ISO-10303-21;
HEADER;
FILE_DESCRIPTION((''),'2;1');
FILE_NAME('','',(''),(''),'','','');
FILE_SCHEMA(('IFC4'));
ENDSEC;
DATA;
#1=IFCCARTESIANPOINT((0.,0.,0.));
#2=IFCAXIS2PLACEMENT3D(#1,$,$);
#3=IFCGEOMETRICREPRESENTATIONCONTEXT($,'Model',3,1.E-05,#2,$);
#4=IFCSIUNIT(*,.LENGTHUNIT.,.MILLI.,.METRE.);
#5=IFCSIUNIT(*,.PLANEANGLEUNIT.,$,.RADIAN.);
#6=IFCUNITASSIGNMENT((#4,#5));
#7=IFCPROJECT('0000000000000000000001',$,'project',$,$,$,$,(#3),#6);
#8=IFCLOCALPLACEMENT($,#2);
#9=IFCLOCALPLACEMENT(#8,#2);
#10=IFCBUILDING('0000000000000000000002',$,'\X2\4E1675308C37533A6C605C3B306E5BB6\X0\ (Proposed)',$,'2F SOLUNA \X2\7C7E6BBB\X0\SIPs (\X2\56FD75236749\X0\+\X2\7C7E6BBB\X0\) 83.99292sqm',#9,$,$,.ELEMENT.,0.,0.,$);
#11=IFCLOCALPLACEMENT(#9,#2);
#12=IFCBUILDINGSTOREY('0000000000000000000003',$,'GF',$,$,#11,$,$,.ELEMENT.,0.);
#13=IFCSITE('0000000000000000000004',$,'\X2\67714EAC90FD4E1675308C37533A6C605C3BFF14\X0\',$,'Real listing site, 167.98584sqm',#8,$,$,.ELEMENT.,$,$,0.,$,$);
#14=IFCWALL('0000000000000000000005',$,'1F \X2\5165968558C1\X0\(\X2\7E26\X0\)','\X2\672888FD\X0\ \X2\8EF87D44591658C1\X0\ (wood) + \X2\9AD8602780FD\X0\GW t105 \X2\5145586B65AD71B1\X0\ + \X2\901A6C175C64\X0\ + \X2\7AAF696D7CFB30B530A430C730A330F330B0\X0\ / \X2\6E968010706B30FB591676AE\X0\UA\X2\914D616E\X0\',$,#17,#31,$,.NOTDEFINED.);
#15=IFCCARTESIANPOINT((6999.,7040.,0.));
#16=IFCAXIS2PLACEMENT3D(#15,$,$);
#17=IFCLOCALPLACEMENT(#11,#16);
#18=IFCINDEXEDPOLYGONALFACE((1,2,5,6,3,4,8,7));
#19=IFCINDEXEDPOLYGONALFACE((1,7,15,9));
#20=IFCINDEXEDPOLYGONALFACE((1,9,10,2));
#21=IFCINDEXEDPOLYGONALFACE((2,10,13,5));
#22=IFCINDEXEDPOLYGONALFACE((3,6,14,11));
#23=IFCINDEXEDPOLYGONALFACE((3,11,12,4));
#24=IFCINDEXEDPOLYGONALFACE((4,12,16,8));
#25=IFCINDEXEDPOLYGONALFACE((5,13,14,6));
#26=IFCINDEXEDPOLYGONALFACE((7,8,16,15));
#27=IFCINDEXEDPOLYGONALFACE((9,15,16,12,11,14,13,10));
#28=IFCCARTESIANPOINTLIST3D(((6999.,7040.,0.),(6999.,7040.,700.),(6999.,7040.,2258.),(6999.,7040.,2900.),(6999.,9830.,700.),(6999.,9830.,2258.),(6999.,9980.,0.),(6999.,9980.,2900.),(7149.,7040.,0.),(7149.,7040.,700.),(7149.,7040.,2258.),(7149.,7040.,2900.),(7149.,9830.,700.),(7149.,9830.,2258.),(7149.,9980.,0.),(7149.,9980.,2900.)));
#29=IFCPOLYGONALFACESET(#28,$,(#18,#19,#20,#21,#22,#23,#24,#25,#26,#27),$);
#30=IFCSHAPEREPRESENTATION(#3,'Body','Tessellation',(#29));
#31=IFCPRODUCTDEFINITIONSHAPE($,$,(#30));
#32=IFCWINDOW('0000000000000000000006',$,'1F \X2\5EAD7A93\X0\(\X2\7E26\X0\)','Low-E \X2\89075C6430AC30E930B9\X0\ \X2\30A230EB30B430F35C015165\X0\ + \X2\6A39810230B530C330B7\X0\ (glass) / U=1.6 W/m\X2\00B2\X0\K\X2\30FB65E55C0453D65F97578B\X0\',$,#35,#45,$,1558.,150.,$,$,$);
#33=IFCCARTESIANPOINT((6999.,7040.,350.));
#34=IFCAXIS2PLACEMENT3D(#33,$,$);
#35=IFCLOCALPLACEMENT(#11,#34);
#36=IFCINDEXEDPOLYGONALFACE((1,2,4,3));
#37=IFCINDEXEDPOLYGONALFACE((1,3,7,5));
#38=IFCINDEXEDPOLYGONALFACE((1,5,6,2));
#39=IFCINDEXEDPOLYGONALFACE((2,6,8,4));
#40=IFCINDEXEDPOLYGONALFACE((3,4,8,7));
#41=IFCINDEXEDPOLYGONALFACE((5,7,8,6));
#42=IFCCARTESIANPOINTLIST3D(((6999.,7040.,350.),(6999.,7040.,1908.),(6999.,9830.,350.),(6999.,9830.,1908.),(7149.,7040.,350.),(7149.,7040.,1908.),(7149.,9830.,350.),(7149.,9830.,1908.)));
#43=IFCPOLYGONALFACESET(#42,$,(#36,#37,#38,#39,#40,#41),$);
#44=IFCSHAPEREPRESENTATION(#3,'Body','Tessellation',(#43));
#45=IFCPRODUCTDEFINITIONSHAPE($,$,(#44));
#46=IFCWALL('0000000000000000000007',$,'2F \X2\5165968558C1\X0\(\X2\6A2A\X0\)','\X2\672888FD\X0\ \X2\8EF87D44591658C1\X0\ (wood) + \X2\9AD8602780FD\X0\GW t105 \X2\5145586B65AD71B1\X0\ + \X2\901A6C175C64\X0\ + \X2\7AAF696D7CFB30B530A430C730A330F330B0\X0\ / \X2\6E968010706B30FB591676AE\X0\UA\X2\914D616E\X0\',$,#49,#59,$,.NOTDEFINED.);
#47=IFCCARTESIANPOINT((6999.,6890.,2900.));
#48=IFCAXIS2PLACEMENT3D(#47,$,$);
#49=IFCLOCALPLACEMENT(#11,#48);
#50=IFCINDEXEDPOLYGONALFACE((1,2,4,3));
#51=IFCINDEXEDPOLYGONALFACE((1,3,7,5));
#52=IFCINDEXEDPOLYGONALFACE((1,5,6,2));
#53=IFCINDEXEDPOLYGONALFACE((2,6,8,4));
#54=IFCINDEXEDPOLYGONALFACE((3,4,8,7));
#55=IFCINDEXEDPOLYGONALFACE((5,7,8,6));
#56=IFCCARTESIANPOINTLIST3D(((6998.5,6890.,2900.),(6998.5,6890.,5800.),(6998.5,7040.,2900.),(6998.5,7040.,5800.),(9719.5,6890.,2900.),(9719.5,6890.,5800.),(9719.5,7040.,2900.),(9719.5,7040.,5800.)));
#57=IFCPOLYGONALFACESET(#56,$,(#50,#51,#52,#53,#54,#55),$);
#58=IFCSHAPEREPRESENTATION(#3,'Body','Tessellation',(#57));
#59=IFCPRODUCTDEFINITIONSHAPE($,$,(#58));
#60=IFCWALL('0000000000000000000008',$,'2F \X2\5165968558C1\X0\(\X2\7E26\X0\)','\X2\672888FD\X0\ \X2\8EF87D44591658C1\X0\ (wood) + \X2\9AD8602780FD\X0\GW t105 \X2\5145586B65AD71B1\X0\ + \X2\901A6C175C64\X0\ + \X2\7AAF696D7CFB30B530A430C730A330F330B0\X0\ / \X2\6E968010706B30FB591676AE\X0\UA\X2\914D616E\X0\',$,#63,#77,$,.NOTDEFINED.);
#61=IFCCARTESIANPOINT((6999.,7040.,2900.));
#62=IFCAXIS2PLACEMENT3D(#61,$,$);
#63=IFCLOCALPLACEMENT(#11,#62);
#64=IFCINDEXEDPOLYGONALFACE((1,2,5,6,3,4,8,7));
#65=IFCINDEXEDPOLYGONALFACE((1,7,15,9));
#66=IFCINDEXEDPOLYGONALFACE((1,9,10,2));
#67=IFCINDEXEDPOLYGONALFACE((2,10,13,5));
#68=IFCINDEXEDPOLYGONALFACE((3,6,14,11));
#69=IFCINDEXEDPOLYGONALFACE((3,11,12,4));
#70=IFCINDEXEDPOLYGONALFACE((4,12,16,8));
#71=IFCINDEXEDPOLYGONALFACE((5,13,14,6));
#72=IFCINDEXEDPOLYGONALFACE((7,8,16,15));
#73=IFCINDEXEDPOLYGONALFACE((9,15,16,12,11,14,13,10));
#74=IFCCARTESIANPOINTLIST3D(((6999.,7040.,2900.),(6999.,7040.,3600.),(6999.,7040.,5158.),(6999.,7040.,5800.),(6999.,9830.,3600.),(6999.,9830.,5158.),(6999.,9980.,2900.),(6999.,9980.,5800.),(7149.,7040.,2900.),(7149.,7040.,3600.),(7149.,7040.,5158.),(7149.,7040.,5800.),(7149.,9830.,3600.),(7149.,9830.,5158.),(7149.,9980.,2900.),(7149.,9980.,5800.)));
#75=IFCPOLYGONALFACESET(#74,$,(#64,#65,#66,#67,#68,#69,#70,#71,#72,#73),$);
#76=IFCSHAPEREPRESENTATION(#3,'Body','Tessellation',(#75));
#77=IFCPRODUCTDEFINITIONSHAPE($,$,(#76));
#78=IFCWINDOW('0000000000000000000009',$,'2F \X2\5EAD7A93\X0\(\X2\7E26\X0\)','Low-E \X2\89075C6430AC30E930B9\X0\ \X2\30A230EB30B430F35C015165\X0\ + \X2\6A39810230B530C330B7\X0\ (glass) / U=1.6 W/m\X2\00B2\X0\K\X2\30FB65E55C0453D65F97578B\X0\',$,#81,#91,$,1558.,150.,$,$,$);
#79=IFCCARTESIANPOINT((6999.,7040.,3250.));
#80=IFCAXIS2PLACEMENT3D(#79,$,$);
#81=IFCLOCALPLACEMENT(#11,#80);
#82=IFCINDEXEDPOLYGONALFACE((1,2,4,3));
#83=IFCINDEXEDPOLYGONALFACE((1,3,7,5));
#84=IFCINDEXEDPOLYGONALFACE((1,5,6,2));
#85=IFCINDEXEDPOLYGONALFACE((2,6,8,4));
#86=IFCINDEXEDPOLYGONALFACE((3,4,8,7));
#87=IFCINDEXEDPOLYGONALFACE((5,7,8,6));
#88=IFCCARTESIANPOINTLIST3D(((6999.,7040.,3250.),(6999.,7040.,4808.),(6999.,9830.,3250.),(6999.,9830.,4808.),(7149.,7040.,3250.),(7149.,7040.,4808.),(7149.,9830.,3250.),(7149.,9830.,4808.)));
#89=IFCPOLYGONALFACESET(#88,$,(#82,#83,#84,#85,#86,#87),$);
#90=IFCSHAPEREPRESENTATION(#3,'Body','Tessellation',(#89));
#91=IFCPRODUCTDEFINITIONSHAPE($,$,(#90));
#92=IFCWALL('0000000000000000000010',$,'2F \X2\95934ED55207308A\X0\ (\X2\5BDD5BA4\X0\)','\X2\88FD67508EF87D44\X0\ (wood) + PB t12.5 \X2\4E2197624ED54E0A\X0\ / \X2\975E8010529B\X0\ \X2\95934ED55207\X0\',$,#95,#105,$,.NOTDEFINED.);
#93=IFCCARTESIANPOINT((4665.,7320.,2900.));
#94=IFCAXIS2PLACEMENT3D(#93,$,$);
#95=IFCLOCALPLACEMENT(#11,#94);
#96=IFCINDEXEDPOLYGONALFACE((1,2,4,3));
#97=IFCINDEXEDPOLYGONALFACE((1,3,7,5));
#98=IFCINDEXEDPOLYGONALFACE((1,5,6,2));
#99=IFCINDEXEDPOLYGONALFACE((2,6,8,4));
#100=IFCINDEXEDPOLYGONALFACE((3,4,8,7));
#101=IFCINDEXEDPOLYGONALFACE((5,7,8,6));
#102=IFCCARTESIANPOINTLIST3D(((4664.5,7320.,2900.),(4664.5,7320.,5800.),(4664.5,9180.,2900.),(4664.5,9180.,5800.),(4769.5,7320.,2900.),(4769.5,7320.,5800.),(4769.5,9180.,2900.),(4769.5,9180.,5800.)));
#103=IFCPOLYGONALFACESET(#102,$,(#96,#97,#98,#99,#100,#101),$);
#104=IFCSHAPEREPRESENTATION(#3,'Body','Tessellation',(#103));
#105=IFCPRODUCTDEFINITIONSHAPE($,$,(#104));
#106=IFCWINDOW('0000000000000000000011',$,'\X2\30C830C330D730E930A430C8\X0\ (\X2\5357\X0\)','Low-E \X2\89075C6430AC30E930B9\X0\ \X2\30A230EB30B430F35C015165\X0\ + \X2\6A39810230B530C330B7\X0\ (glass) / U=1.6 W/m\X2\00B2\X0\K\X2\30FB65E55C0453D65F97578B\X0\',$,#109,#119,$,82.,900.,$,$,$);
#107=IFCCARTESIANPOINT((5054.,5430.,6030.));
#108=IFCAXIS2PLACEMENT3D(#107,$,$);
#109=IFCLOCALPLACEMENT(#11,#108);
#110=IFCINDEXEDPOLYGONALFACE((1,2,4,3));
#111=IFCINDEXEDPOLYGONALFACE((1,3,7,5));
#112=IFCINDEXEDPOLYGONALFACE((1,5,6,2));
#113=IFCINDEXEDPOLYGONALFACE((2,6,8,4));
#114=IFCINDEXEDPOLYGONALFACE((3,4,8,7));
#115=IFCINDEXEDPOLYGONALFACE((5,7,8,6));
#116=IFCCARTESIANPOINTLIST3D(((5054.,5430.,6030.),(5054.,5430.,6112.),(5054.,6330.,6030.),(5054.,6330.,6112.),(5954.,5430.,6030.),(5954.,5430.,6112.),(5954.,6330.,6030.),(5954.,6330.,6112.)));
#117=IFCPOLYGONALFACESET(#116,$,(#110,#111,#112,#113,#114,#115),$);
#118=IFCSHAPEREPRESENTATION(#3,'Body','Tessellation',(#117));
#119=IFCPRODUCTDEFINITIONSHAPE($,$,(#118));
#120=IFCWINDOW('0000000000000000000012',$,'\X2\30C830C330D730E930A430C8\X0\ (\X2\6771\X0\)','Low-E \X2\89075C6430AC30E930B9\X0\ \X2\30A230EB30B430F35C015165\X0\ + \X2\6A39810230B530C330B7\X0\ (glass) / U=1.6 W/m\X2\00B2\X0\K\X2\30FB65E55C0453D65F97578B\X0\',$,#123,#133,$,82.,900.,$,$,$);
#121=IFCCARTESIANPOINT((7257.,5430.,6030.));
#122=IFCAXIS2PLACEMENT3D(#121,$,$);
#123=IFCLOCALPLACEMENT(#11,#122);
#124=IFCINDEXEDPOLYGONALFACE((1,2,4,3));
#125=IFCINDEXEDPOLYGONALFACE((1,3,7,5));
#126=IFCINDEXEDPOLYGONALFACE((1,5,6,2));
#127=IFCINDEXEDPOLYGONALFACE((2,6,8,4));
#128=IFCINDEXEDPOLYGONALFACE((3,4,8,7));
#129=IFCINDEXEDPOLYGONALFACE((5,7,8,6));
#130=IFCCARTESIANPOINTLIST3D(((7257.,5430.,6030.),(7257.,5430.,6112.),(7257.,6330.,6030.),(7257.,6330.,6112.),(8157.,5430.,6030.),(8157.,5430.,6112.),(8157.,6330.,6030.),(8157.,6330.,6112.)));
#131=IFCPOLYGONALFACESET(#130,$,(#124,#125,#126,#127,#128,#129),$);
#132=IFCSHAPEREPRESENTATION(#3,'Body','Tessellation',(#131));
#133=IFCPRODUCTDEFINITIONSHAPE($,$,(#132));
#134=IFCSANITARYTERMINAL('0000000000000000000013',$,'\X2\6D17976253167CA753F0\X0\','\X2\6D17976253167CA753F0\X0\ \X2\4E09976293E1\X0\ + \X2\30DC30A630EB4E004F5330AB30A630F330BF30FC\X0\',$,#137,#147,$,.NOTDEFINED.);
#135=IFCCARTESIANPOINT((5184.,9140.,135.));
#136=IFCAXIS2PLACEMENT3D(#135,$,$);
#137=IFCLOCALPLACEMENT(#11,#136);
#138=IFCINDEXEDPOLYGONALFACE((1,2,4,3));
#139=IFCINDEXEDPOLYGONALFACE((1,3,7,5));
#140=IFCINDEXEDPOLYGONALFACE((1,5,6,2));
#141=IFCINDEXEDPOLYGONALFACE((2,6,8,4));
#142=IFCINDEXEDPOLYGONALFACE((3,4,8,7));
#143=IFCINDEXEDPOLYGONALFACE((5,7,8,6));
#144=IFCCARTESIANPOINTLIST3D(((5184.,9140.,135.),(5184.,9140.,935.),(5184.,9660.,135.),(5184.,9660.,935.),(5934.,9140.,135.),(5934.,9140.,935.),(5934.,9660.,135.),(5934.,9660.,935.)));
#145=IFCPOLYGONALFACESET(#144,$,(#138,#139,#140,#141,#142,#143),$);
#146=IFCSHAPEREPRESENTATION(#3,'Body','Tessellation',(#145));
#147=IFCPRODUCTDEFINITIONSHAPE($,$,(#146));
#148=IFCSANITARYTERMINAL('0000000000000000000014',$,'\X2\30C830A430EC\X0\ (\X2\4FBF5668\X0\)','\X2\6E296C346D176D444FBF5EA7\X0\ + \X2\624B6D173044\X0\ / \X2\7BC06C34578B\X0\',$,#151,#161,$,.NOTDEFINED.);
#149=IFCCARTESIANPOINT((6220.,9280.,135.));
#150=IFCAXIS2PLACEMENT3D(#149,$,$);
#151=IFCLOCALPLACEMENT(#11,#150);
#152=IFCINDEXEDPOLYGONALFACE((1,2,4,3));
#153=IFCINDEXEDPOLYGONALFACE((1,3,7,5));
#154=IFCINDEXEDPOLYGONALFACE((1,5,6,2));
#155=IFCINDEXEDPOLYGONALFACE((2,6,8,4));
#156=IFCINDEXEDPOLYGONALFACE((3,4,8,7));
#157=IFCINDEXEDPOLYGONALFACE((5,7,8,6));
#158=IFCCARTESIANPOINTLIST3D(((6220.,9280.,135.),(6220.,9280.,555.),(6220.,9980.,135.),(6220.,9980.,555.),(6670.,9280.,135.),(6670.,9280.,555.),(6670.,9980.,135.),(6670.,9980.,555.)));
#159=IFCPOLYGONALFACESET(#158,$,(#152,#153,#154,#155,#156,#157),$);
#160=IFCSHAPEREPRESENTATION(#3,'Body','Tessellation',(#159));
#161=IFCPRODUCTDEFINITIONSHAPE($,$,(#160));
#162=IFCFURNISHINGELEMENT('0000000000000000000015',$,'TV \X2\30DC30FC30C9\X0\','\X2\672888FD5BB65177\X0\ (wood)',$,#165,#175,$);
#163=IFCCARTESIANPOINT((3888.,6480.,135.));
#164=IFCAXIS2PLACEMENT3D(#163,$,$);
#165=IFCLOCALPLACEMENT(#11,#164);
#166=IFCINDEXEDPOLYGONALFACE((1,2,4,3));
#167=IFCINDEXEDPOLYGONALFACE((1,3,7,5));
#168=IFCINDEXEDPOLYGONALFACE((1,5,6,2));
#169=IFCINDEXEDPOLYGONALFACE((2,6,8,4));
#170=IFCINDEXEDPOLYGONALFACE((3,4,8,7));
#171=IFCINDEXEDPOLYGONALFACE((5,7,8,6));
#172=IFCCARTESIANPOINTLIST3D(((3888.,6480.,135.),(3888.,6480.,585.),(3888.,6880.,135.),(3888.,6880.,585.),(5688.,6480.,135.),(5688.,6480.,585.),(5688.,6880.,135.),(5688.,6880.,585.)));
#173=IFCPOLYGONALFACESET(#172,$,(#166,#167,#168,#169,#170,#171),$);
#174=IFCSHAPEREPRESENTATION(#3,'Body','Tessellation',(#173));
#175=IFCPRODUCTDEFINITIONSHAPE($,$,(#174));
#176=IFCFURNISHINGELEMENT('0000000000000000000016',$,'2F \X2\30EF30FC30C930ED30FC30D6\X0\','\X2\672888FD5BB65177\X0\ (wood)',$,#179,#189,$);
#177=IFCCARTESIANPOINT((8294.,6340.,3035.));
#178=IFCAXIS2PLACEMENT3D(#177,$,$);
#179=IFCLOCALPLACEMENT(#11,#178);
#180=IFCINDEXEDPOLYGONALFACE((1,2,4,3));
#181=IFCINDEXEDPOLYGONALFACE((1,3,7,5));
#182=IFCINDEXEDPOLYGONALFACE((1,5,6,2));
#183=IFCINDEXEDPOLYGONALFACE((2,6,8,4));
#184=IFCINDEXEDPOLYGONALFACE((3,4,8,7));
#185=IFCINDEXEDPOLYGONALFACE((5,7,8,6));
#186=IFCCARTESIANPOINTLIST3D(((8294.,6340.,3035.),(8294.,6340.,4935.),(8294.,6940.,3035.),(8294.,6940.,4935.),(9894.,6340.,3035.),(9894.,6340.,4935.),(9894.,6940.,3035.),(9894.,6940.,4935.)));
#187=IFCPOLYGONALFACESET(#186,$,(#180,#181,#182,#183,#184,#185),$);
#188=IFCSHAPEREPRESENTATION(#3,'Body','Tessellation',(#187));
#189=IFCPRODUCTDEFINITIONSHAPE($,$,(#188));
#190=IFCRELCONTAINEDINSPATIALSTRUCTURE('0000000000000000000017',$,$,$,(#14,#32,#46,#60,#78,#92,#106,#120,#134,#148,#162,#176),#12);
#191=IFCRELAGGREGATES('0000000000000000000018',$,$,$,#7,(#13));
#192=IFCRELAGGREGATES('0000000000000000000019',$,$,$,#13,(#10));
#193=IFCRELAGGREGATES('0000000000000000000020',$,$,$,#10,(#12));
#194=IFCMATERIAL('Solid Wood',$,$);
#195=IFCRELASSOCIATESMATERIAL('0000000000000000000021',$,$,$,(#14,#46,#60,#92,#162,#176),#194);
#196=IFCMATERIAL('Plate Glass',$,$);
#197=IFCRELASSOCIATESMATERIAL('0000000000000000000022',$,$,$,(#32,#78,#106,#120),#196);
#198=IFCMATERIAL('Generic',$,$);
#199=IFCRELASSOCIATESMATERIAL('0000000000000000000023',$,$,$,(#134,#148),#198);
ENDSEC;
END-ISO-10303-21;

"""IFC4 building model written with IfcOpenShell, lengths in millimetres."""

from ifc_helpers import new_model, si_unit, frame, frame_2d, origin, place, context, project, spatial, rectangle, extrude, material, element, fill, save


model = new_model("IFC4")

# Units and contexts
model_context = context("Model", 3, precision=1e-05, world=origin())
ifc_project = project(units=[si_unit("LENGTHUNIT", "METRE", prefix="MILLI"), si_unit("PLANEANGLEUNIT", "RADIAN")], contexts=[model_context])

# Site, building, storey
site_placement = place(None, origin())
site = spatial("IfcSite", under=ifc_project, at=site_placement, Name="東京都世田谷区池尻４", ObjectType="Real listing site, 167.98584sqm", CompositionType="ELEMENT", RefElevation=0.0)
building_placement = place(site_placement, origin())
building = spatial("IfcBuilding", under=site, at=building_placement, Name="世田谷区池尻の家 (Proposed)", ObjectType="2F SOLUNA 籾殻SIPs (国産杉+籾殻) 83.99292sqm", CompositionType="ELEMENT", ElevationOfRefHeight=0.0, ElevationOfTerrain=0.0)
storey_placement = place(building_placement, origin())
storey = spatial("IfcBuildingStorey", under=building, at=storey_placement, Name="GF", CompositionType="ELEMENT", Elevation=0.0)

# Shared definitions
ifc_material_1 = material(Name="Solid Wood")

# Wall, opening, window
wall_1_placement = place(storey_placement, frame((6999.0, 7040.0, 0.0)))
wall_1 = element("IfcWall", 1, at=wall_1_placement, inside=storey, material=ifc_material_1, Name="1F 入隅壁(縦)", Description="木製 軸組外壁 (wood) + 高性能GW t105 充填断熱 + 通気層 + 窯業系サイディング / 準耐火・外皮UA配慮", PredefinedType="NOTDEFINED", context=model_context, shape_type="SweptSolid", body=[
    extrude(rectangle(XDim=150.0, YDim=2940.0, at=frame_2d((75.0, 1470.0))), frame((6999.0, 7040.0, 0.0)), (0.0, 0.0, 1.0), 2900.0),
])
opening_1_placement = place(storey_placement, frame((6999.0, 7040.0, 350.0)))
opening_1 = element("IfcOpeningElement", 2, at=opening_1_placement, cuts=wall_1, PredefinedType="NOTDEFINED", context=model_context, shape_type="SweptSolid", body=[
    extrude(rectangle(XDim=150.0, YDim=2790.0, at=frame_2d((75.0, 1395.0))), frame((6999.0, 7040.0, 350.0)), (0.0, 0.0, 1.0), 1558.0),
])
ifc_material_2 = material(Name="Plate Glass")
window_1_placement = place(storey_placement, frame((6999.0, 7040.0, 350.0)))
window_1 = element("IfcWindow", 3, at=window_1_placement, inside=storey, material=ifc_material_2, Name="1F 庭窓(縦)", Description="Low-E 複層ガラス アルゴン封入 + 樹脂サッシ (glass) / U=1.6 W/m²K・日射取得型", OverallHeight=1558.0, OverallWidth=150.0, context=model_context, shape_type="SweptSolid", body=[
    extrude(rectangle(XDim=150.0, YDim=2790.0, at=frame_2d((75.0, 1395.0))), frame((6999.0, 7040.0, 350.0)), (0.0, 0.0, 1.0), 1558.0),
])
fill(opening_1, window_1)

# Wall
wall_2_placement = place(storey_placement, frame((6999.0, 6890.0, 2900.0)))
element("IfcWall", 4, at=wall_2_placement, inside=storey, material=ifc_material_1, Name="2F 入隅壁(横)", Description="木製 軸組外壁 (wood) + 高性能GW t105 充填断熱 + 通気層 + 窯業系サイディング / 準耐火・外皮UA配慮", PredefinedType="NOTDEFINED", context=model_context, shape_type="SweptSolid", body=[
    extrude(rectangle(XDim=2721.0, YDim=150.0, at=frame_2d((1360.0, 75.0))), frame((6999.0, 6890.0, 2900.0)), (0.0, 0.0, 1.0), 2900.0),
])

# Wall, opening, window
wall_3_placement = place(storey_placement, frame((6999.0, 7040.0, 2900.0)))
wall_3 = element("IfcWall", 5, at=wall_3_placement, inside=storey, material=ifc_material_1, Name="2F 入隅壁(縦)", Description="木製 軸組外壁 (wood) + 高性能GW t105 充填断熱 + 通気層 + 窯業系サイディング / 準耐火・外皮UA配慮", PredefinedType="NOTDEFINED", context=model_context, shape_type="SweptSolid", body=[
    extrude(rectangle(XDim=150.0, YDim=2940.0, at=frame_2d((75.0, 1470.0))), frame((6999.0, 7040.0, 2900.0)), (0.0, 0.0, 1.0), 2900.0),
])
opening_2_placement = place(storey_placement, frame((6999.0, 7040.0, 3250.0)))
opening_2 = element("IfcOpeningElement", 6, at=opening_2_placement, cuts=wall_3, PredefinedType="NOTDEFINED", context=model_context, shape_type="SweptSolid", body=[
    extrude(rectangle(XDim=150.0, YDim=2790.0, at=frame_2d((75.0, 1395.0))), frame((6999.0, 7040.0, 3250.0)), (0.0, 0.0, 1.0), 1558.0),
])
window_2_placement = place(storey_placement, frame((6999.0, 7040.0, 3250.0)))
window_2 = element("IfcWindow", 7, at=window_2_placement, inside=storey, material=ifc_material_2, Name="2F 庭窓(縦)", Description="Low-E 複層ガラス アルゴン封入 + 樹脂サッシ (glass) / U=1.6 W/m²K・日射取得型", OverallHeight=1558.0, OverallWidth=150.0, context=model_context, shape_type="SweptSolid", body=[
    extrude(rectangle(XDim=150.0, YDim=2790.0, at=frame_2d((75.0, 1395.0))), frame((6999.0, 7040.0, 3250.0)), (0.0, 0.0, 1.0), 1558.0),
])
fill(opening_2, window_2)

# Wall
wall_4_placement = place(storey_placement, frame((4665.0, 7320.0, 2900.0)))
element("IfcWall", 8, at=wall_4_placement, inside=storey, material=ifc_material_1, Name="2F 間仕切り (寝室)", Description="製材軸組 (wood) + PB t12.5 両面仕上 / 非耐力 間仕切", PredefinedType="NOTDEFINED", context=model_context, shape_type="SweptSolid", body=[
    extrude(rectangle(XDim=105.0, YDim=1860.0, at=frame_2d((52.0, 930.0))), frame((4665.0, 7320.0, 2900.0)), (0.0, 0.0, 1.0), 2900.0),
])

# Windows
window_3_placement = place(storey_placement, frame((5054.0, 5430.0, 6030.0)))
element("IfcWindow", 9, at=window_3_placement, inside=storey, material=ifc_material_2, Name="トップライト (南)", Description="Low-E 複層ガラス アルゴン封入 + 樹脂サッシ (glass) / U=1.6 W/m²K・日射取得型", OverallHeight=82.0, OverallWidth=900.0, context=model_context, shape_type="SweptSolid", body=[
    extrude(rectangle(XDim=900.0, YDim=900.0, at=frame_2d((450.0, 450.0))), frame((5054.0, 5430.0, 6030.0)), (0.0, 0.0, 1.0), 82.0),
])
window_4_placement = place(storey_placement, frame((7257.0, 5430.0, 6030.0)))
element("IfcWindow", 10, at=window_4_placement, inside=storey, material=ifc_material_2, Name="トップライト (東)", Description="Low-E 複層ガラス アルゴン封入 + 樹脂サッシ (glass) / U=1.6 W/m²K・日射取得型", OverallHeight=82.0, OverallWidth=900.0, context=model_context, shape_type="SweptSolid", body=[
    extrude(rectangle(XDim=900.0, YDim=900.0, at=frame_2d((450.0, 450.0))), frame((7257.0, 5430.0, 6030.0)), (0.0, 0.0, 1.0), 82.0),
])

# Sanitary terminals
ifc_material_3 = material(Name="Generic")
sanitary_terminal_1_placement = place(storey_placement, frame((5184.0, 9140.0, 135.0)))
element("IfcSanitaryTerminal", 11, at=sanitary_terminal_1_placement, inside=storey, material=ifc_material_3, Name="洗面化粧台", Description="洗面化粧台 三面鏡 + ボウル一体カウンター", PredefinedType="NOTDEFINED", context=model_context, shape_type="SweptSolid", body=[
    extrude(rectangle(XDim=750.0, YDim=520.0, at=frame_2d((375.0, 260.0))), frame((5184.0, 9140.0, 135.0)), (0.0, 0.0, 1.0), 800.0),
])
sanitary_terminal_2_placement = place(storey_placement, frame((6220.0, 9280.0, 135.0)))
element("IfcSanitaryTerminal", 12, at=sanitary_terminal_2_placement, inside=storey, material=ifc_material_3, Name="トイレ (便器)", Description="温水洗浄便座 + 手洗い / 節水型", PredefinedType="NOTDEFINED", context=model_context, shape_type="SweptSolid", body=[
    extrude(rectangle(XDim=450.0, YDim=700.0, at=frame_2d((225.0, 350.0))), frame((6220.0, 9280.0, 135.0)), (0.0, 0.0, 1.0), 420.0),
])

# Furnishing elements
furnishing_1_placement = place(storey_placement, frame((3888.0, 6480.0, 135.0)))
element("IfcFurnishingElement", 13, at=furnishing_1_placement, inside=storey, material=ifc_material_1, Name="TV ボード", Description="木製家具 (wood)", context=model_context, shape_type="SweptSolid", body=[
    extrude(rectangle(XDim=1800.0, YDim=400.0, at=frame_2d((900.0, 200.0))), frame((3888.0, 6480.0, 135.0)), (0.0, 0.0, 1.0), 450.0),
])
furnishing_2_placement = place(storey_placement, frame((8294.0, 6340.0, 3035.0)))
element("IfcFurnishingElement", 14, at=furnishing_2_placement, inside=storey, material=ifc_material_1, Name="2F ワードローブ", Description="木製家具 (wood)", context=model_context, shape_type="SweptSolid", body=[
    extrude(rectangle(XDim=1600.0, YDim=600.0, at=frame_2d((800.0, 300.0))), frame((8294.0, 6340.0, 3035.0)), (0.0, 0.0, 1.0), 1900.0),
])

save(model, "model.ifc")
